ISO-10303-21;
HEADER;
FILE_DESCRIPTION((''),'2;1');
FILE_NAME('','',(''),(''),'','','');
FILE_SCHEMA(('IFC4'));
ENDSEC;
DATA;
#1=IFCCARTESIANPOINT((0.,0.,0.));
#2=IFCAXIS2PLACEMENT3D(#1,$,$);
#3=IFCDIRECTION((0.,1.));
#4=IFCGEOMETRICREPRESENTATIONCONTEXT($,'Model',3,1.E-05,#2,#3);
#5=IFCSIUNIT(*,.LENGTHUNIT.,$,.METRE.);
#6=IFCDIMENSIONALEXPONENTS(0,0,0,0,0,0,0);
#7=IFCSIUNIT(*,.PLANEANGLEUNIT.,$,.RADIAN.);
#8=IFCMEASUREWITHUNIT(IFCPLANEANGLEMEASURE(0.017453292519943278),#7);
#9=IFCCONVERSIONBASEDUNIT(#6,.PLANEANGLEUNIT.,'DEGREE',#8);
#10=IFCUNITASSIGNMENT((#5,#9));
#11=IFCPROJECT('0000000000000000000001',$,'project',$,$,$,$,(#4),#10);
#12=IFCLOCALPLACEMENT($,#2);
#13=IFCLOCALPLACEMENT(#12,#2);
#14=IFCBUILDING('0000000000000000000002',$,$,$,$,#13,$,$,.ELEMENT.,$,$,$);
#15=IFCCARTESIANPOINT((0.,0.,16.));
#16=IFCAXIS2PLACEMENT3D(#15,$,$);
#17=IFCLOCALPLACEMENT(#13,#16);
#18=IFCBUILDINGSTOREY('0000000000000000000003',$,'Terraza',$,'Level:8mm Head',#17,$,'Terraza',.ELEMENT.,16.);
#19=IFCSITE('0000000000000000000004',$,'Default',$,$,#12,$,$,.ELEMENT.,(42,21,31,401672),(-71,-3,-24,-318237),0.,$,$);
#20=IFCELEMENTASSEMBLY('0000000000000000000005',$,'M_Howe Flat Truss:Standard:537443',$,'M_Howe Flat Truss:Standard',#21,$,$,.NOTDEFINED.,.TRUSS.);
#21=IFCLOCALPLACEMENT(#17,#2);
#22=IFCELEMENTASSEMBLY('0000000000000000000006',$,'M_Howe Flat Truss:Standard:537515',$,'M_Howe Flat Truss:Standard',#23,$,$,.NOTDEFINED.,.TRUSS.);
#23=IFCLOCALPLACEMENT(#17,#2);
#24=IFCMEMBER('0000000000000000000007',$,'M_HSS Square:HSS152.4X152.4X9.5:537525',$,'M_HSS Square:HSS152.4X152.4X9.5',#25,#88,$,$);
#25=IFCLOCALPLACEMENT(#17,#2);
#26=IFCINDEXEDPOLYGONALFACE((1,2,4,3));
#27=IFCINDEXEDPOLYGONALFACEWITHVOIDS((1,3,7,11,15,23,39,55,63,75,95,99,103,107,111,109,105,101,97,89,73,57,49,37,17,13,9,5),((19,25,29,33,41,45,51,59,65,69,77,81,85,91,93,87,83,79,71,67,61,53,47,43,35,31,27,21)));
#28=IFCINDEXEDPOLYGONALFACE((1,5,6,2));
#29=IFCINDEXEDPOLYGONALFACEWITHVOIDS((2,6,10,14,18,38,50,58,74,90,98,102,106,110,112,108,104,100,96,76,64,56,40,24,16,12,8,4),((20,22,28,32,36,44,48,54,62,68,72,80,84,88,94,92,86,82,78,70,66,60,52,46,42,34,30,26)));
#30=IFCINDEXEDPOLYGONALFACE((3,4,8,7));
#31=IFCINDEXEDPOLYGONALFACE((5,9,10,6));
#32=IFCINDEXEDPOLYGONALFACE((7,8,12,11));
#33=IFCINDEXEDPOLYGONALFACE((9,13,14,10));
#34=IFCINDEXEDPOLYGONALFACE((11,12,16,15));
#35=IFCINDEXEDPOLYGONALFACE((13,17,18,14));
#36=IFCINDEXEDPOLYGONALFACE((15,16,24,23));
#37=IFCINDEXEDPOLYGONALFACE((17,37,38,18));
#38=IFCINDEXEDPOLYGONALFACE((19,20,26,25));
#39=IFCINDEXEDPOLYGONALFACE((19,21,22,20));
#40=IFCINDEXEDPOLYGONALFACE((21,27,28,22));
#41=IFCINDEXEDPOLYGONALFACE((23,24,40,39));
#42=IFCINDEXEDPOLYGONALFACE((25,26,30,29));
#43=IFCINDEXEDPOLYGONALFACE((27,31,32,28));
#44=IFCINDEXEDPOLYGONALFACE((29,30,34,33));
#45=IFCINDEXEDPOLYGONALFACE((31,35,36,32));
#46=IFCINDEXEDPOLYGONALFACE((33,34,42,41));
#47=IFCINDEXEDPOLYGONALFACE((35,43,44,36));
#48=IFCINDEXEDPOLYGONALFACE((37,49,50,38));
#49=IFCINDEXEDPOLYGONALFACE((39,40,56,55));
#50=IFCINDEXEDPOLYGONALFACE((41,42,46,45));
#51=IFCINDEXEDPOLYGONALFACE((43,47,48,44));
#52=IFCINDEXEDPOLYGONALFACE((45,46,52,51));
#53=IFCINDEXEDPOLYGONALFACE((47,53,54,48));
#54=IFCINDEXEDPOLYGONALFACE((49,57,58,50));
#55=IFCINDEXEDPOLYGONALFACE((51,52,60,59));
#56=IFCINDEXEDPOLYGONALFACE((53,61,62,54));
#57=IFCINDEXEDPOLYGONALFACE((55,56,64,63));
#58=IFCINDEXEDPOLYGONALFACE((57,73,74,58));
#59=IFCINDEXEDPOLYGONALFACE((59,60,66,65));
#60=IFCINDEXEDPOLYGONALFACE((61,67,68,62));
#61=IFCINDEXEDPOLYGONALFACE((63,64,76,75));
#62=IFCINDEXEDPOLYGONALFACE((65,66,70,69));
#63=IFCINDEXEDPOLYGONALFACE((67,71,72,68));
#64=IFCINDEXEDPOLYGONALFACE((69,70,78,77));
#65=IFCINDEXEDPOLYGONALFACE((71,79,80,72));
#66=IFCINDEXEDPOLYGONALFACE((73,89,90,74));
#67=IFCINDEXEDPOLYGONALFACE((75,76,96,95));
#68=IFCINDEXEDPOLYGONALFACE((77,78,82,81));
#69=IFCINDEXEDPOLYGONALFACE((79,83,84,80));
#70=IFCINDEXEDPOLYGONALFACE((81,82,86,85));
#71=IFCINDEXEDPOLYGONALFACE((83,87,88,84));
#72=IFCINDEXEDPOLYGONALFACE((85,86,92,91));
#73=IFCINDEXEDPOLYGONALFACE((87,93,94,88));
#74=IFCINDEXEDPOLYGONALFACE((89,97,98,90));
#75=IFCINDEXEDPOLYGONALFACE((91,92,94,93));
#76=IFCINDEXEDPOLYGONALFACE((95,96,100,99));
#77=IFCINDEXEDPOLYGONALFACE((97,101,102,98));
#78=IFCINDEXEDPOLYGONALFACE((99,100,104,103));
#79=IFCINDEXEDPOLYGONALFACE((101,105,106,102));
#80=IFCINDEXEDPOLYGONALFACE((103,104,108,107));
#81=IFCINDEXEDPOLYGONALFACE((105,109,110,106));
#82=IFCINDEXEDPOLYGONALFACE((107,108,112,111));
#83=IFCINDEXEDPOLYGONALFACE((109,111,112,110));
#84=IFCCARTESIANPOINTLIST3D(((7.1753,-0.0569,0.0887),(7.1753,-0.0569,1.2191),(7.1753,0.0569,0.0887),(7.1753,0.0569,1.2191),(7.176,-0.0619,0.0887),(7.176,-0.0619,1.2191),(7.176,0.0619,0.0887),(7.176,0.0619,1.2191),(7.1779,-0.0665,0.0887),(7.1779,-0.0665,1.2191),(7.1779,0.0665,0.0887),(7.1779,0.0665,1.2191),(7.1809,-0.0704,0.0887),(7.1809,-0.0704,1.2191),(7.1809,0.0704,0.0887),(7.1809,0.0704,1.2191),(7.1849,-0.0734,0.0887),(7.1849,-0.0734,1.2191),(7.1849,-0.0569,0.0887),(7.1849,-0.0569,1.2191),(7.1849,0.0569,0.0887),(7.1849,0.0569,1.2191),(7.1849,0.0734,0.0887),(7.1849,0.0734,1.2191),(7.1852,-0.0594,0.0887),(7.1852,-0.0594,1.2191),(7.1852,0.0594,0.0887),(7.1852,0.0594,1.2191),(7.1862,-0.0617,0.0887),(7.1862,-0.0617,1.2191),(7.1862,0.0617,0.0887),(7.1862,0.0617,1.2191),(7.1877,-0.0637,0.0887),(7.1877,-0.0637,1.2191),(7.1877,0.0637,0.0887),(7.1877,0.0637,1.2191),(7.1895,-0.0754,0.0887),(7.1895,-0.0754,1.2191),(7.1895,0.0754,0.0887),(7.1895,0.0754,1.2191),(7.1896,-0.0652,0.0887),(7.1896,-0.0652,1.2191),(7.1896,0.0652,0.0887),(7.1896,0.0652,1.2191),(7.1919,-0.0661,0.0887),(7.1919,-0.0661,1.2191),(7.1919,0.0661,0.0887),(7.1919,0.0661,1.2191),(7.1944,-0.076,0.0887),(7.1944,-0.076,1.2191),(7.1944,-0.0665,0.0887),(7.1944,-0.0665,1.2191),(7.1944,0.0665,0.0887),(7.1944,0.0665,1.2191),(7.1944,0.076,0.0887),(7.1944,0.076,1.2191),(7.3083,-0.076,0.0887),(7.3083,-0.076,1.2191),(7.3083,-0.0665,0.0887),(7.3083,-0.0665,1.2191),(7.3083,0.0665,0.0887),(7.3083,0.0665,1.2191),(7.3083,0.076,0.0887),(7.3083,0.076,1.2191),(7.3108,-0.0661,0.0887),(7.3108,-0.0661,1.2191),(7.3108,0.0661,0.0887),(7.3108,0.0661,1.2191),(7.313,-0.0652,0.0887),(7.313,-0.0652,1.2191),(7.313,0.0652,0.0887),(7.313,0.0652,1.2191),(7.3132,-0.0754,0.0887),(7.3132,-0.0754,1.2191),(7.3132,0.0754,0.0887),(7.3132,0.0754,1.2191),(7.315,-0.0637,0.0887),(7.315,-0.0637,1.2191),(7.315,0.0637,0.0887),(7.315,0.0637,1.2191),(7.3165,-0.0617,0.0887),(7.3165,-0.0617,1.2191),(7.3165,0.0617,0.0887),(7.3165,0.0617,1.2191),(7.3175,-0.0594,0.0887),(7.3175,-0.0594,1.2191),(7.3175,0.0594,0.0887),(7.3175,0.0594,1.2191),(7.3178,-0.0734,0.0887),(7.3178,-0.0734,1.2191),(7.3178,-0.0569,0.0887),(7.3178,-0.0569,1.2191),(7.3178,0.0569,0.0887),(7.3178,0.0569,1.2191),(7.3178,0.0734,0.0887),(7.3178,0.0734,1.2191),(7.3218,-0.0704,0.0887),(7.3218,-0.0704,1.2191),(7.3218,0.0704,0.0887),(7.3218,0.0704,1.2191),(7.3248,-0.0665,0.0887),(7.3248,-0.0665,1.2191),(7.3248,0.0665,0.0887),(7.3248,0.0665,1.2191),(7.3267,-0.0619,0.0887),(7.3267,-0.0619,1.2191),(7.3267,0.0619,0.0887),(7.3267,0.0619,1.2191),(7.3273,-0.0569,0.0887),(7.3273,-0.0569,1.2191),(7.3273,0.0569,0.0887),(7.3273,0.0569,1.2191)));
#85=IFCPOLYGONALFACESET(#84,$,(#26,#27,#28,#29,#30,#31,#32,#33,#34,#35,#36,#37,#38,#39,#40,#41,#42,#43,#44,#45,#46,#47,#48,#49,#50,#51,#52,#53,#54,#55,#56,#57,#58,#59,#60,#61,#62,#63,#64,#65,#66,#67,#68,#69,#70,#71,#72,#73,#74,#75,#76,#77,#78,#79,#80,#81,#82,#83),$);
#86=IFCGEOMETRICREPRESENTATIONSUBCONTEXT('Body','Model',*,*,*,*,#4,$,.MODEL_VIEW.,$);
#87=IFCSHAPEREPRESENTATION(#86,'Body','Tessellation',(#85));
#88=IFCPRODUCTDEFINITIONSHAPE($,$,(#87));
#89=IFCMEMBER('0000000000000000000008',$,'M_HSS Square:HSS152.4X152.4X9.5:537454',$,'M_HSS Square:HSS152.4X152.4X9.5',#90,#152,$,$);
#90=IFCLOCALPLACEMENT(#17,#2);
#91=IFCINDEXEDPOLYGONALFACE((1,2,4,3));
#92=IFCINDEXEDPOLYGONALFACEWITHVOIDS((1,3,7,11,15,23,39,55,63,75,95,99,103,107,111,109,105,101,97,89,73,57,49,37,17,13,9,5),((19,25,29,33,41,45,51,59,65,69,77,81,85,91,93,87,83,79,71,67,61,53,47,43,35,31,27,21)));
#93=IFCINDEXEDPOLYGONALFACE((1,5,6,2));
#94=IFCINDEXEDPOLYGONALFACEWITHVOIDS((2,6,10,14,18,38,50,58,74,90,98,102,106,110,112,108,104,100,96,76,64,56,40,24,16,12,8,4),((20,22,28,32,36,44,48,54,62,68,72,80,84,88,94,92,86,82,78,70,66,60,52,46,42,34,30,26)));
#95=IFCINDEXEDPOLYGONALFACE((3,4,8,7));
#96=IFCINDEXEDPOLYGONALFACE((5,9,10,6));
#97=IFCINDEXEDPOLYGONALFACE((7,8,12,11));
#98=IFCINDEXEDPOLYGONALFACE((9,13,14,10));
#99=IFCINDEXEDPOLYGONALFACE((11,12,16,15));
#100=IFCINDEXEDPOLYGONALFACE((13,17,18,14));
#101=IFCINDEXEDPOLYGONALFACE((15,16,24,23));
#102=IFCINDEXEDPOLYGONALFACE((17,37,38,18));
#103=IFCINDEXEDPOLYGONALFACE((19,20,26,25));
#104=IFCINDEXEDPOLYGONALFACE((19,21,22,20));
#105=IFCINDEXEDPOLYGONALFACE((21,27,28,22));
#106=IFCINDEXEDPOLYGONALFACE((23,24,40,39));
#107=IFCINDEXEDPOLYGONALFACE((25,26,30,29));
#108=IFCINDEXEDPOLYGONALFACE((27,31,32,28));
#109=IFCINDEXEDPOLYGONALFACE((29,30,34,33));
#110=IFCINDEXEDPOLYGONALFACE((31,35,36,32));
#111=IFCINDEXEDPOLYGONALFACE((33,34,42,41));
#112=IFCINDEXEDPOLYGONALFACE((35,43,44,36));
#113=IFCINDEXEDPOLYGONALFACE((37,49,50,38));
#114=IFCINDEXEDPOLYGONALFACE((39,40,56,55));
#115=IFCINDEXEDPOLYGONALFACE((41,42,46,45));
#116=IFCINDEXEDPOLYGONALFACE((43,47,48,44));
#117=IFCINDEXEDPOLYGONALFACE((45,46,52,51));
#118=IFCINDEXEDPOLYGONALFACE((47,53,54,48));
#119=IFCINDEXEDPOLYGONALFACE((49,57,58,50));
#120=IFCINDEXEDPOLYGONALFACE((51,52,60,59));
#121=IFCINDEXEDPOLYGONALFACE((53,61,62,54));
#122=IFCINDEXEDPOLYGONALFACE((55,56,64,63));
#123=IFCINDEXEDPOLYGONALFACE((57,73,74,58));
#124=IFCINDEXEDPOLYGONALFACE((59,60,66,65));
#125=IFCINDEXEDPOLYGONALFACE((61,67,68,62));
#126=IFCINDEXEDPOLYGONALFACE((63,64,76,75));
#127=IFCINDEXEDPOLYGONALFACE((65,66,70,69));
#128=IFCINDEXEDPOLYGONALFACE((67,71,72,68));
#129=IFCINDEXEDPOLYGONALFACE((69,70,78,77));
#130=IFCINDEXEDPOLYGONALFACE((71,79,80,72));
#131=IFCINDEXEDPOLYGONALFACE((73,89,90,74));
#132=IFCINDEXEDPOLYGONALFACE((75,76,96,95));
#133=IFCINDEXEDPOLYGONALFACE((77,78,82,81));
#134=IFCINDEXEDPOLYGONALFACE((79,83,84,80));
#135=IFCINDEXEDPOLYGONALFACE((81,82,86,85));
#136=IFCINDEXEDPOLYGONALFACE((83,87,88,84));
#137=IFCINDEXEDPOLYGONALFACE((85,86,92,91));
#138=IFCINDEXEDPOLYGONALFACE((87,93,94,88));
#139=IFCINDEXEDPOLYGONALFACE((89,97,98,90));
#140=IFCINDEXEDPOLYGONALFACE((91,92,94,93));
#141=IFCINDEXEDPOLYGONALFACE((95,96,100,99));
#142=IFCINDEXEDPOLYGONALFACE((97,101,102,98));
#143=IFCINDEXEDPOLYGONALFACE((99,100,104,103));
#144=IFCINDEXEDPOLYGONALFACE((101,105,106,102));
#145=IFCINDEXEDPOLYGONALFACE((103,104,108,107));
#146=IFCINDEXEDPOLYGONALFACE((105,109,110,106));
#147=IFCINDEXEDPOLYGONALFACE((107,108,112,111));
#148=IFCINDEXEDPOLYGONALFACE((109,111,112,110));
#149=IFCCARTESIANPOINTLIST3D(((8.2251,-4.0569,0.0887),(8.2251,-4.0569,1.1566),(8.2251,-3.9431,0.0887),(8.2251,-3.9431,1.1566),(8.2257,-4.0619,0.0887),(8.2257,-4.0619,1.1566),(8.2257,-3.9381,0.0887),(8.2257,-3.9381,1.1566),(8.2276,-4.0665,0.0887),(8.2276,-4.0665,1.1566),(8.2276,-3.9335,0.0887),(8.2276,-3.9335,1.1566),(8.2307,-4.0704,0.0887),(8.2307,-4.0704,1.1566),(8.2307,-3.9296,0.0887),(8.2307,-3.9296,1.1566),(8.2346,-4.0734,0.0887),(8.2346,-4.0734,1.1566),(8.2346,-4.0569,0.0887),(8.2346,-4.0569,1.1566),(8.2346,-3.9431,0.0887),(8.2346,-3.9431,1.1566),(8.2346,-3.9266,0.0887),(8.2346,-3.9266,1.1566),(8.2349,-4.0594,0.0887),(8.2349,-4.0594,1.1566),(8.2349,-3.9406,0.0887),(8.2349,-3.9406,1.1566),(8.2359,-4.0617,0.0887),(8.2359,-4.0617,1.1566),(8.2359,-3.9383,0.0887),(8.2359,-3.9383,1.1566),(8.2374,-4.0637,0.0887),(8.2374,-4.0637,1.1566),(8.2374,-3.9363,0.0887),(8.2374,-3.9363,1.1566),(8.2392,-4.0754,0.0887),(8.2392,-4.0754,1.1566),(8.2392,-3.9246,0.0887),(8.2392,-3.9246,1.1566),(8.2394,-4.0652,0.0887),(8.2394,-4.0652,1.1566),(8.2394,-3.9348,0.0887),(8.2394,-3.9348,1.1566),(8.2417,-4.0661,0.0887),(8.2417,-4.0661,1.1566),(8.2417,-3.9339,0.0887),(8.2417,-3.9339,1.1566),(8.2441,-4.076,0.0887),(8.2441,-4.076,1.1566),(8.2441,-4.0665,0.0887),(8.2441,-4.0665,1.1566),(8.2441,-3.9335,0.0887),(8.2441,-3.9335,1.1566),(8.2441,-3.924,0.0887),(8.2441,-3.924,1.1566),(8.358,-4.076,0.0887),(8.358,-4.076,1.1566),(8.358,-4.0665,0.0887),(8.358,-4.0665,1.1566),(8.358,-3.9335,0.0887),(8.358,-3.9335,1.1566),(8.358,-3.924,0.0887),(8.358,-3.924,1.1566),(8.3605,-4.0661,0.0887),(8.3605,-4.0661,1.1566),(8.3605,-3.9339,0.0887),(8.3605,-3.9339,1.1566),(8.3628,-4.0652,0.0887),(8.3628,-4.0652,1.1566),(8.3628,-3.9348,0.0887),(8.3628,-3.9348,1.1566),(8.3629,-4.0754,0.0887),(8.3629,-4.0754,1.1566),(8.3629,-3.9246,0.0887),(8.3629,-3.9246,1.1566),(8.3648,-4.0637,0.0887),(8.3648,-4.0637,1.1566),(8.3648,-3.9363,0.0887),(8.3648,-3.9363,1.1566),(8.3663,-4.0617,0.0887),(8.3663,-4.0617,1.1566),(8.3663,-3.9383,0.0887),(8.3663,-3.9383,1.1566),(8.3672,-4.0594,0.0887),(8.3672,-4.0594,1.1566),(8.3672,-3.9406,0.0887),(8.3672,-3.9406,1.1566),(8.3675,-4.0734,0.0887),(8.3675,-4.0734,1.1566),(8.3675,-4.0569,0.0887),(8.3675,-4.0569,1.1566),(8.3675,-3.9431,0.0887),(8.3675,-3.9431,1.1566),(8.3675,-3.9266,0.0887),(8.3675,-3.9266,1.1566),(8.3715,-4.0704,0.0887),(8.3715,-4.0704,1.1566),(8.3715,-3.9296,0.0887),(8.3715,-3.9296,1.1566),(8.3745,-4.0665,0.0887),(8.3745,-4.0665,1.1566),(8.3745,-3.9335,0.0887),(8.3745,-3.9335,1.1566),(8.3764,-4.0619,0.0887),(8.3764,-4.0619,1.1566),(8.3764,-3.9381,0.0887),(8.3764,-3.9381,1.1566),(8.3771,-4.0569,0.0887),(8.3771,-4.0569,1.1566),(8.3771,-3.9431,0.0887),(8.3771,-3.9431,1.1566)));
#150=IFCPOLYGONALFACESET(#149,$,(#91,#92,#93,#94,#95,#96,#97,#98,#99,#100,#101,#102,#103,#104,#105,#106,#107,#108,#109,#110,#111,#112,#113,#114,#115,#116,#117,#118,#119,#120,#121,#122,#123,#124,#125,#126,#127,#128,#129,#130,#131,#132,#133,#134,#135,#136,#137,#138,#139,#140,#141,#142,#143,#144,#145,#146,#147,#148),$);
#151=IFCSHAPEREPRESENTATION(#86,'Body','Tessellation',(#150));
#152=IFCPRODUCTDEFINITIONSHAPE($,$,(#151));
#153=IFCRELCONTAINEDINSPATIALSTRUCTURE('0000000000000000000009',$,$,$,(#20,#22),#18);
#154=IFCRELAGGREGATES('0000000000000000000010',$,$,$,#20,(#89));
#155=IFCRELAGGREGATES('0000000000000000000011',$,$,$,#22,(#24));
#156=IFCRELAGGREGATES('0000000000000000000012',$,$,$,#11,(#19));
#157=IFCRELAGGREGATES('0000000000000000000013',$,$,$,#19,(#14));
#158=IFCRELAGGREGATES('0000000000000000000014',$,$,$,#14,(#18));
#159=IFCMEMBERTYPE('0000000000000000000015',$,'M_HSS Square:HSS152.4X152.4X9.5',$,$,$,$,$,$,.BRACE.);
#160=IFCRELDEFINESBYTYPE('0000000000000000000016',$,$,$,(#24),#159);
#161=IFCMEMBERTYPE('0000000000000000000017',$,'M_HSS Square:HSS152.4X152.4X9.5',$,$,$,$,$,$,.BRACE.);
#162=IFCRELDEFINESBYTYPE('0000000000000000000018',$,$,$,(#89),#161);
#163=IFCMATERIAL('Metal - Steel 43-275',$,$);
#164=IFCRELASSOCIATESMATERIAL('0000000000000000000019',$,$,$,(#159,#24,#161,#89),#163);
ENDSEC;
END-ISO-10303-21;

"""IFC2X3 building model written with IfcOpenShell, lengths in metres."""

from ifc_helpers import new_model, entity, si_unit, converted_unit, direction, frame, frame_2d, origin, place, context, subcontext, project, spatial, polyline, circle_curve, parameter, trimmed, segment, composite_curve, outline, extrude, source, transform, mapped, material, type_object, type_shapes, element, aggregate, save


model = new_model("IFC2X3")

# Units and contexts
model_context = context("Model", 3, precision=1e-05, world=origin(), true_north=direction((0.0, 1.0)))
body_context = subcontext(model_context, "Body", "Model", "MODEL_VIEW")
ifc_project = project(units=[si_unit("LENGTHUNIT", "METRE"), converted_unit("PLANEANGLEUNIT", "DEGREE", entity("IfcPlaneAngleMeasure", 0.017453292519943278), si_unit("PLANEANGLEUNIT", "RADIAN"), dimensions=[0, 0, 0, 0, 0, 0, 0])], contexts=[model_context])

# Site, building, storey
site_placement = place(None, origin())
site = spatial("IfcSite", under=ifc_project, at=site_placement, Name="Default", CompositionType="ELEMENT", RefLatitude=(42, 21, 31, 401672), RefLongitude=(-71, -3, -24, -318237), RefElevation=0.0)
building_placement = place(site_placement, origin())
building = spatial("IfcBuilding", under=site, at=building_placement, CompositionType="ELEMENT")
storey_placement = place(building_placement, frame((0.0, 0.0, 16.0)))
storey = spatial("IfcBuildingStorey", under=building, at=storey_placement, Name="Terraza", ObjectType="Level:8mm Head", LongName="Terraza", CompositionType="ELEMENT", Elevation=16.0)

# Element assemblies
ifc_material_1 = material(Name="Metal - Steel 43-275")
assembly_1_placement = place(storey_placement, origin())
assembly_1 = element("IfcElementAssembly", 1, at=assembly_1_placement, inside=storey, Name="M_Howe Flat Truss:Standard:537443", ObjectType="M_Howe Flat Truss:Standard", AssemblyPlace="NOTDEFINED", PredefinedType="TRUSS")
assembly_2_placement = place(storey_placement, origin())
assembly_2 = element("IfcElementAssembly", 2, at=assembly_2_placement, inside=storey, Name="M_Howe Flat Truss:Standard:537515", ObjectType="M_Howe Flat Truss:Standard", AssemblyPlace="NOTDEFINED", PredefinedType="TRUSS")

# Members
member_type_1 = type_object("IfcMemberType", Name="M_HSS Square:HSS152.4X152.4X9.5", PredefinedType="BRACE", material=ifc_material_1)
shared_shape_1 = source(origin(), body_context, "Body", "SweptSolid", [
    extrude(outline(composite_curve([segment(polyline([(-0.0569, -0.076), (0.0569, -0.076)]), True, "CONTINUOUS"), segment(trimmed(circle_curve(frame_2d((0.0569, -0.0569), x_axis=(0.0, 1.0)), 0.0191), [parameter(180.0)], [parameter(270.0)], True, "PARAMETER"), True, "CONTINUOUS"), segment(polyline([(0.076, -0.0569), (0.076, 0.0569)]), True, "CONTINUOUS"), segment(trimmed(circle_curve(frame_2d((0.0569, 0.0569), x_axis=(0.0, 1.0)), 0.0191), [parameter(270.0)], [parameter(0.0)], True, "PARAMETER"), True, "CONTINUOUS"), segment(polyline([(0.0569, 0.076), (-0.0569, 0.076)]), True, "CONTINUOUS"), segment(trimmed(circle_curve(frame_2d((-0.0569, 0.0569), x_axis=(0.0, 1.0)), 0.0191), [parameter(0.0)], [parameter(90.0)], True, "PARAMETER"), True, "CONTINUOUS"), segment(polyline([(-0.076, 0.0569), (-0.076, -0.0569)]), True, "CONTINUOUS"), segment(trimmed(circle_curve(frame_2d((-0.0569, -0.0569), x_axis=(0.0, 1.0)), 0.0191), [parameter(90.0)], [parameter(180.0)], True, "PARAMETER"), True, "CONTINUOUS")], self_intersect=False), holes=[composite_curve([segment(trimmed(circle_curve(frame_2d((-0.0569, 0.0569), x_axis=(0.0, 1.0)), 0.0095), [parameter(360.0)], [parameter(90.0)], True, "PARAMETER"), False, "CONTINUOUS"), segment(polyline([(-0.0569, 0.0665), (0.0569, 0.0665)]), True, "CONTINUOUS"), segment(trimmed(circle_curve(frame_2d((0.0569, 0.0569), x_axis=(0.0, 1.0)), 0.0095), [parameter(270.0)], [parameter(360.0)], True, "PARAMETER"), False, "CONTINUOUS"), segment(polyline([(0.0665, 0.0569), (0.0665, -0.0569)]), True, "CONTINUOUS"), segment(trimmed(circle_curve(frame_2d((0.0569, -0.0569), x_axis=(0.0, 1.0)), 0.0095), [parameter(180.0)], [parameter(270.0)], True, "PARAMETER"), False, "CONTINUOUS"), segment(polyline([(0.0569, -0.0665), (-0.0569, -0.0665)]), True, "CONTINUOUS"), segment(trimmed(circle_curve(frame_2d((-0.0569, -0.0569), x_axis=(0.0, 1.0)), 0.0095), [parameter(90.0)], [parameter(180.0)], True, "PARAMETER"), False, "CONTINUOUS"), segment(polyline([(-0.0665, -0.0569), (-0.0665, 0.0569)]), True, "CONTINUOUS")], self_intersect=False)]), frame((-0.5675, 0.0, 0.0), z_axis=(1.0, 0.0, 0.0), x_axis=(0.0, 0.0, -1.0)), (0.0, 0.0, 1.0), 1.1304),
])
type_shapes(member_type_1, [shared_shape_1])
member_1_placement = place(assembly_2_placement, frame((7.2513, 0.0, 0.6562), z_axis=(1.0, 0.0, 0.0), x_axis=(0.0, 0.0, 1.0)))
member_1 = element("IfcMember", 3, at=member_1_placement, type_object=member_type_1, material=ifc_material_1, Name="M_HSS Square:HSS152.4X152.4X9.5:537525", ObjectType="M_HSS Square:HSS152.4X152.4X9.5", context=body_context, shape_type="MappedRepresentation", body=[
    mapped(shared_shape_1, transform((0.0, 0.0, 0.0), scale=1.0)),
])
member_type_2 = type_object("IfcMemberType", Name="M_HSS Square:HSS152.4X152.4X9.5", PredefinedType="BRACE", material=ifc_material_1)
shared_shape_2 = source(origin(), body_context, "Body", "SweptSolid", [
    extrude(outline(composite_curve([segment(polyline([(-0.0569, -0.076), (0.0569, -0.076)]), True, "CONTINUOUS"), segment(trimmed(circle_curve(frame_2d((0.0569, -0.0569), x_axis=(0.0, 1.0)), 0.0191), [parameter(180.0)], [parameter(270.0)], True, "PARAMETER"), True, "CONTINUOUS"), segment(polyline([(0.076, -0.0569), (0.076, 0.0569)]), True, "CONTINUOUS"), segment(trimmed(circle_curve(frame_2d((0.0569, 0.0569), x_axis=(0.0, 1.0)), 0.0191), [parameter(270.0)], [parameter(0.0)], True, "PARAMETER"), True, "CONTINUOUS"), segment(polyline([(0.0569, 0.076), (-0.0569, 0.076)]), True, "CONTINUOUS"), segment(trimmed(circle_curve(frame_2d((-0.0569, 0.0569), x_axis=(0.0, 1.0)), 0.0191), [parameter(0.0)], [parameter(90.0)], True, "PARAMETER"), True, "CONTINUOUS"), segment(polyline([(-0.076, 0.0569), (-0.076, -0.0569)]), True, "CONTINUOUS"), segment(trimmed(circle_curve(frame_2d((-0.0569, -0.0569), x_axis=(0.0, 1.0)), 0.0191), [parameter(90.0)], [parameter(180.0)], True, "PARAMETER"), True, "CONTINUOUS")], self_intersect=False), holes=[composite_curve([segment(trimmed(circle_curve(frame_2d((-0.0569, 0.0569), x_axis=(0.0, 1.0)), 0.0095), [parameter(360.0)], [parameter(90.0)], True, "PARAMETER"), False, "CONTINUOUS"), segment(polyline([(-0.0569, 0.0665), (0.0569, 0.0665)]), True, "CONTINUOUS"), segment(trimmed(circle_curve(frame_2d((0.0569, 0.0569), x_axis=(0.0, 1.0)), 0.0095), [parameter(270.0)], [parameter(360.0)], True, "PARAMETER"), False, "CONTINUOUS"), segment(polyline([(0.0665, 0.0569), (0.0665, -0.0569)]), True, "CONTINUOUS"), segment(trimmed(circle_curve(frame_2d((0.0569, -0.0569), x_axis=(0.0, 1.0)), 0.0095), [parameter(180.0)], [parameter(270.0)], True, "PARAMETER"), False, "CONTINUOUS"), segment(polyline([(0.0569, -0.0665), (-0.0569, -0.0665)]), True, "CONTINUOUS"), segment(trimmed(circle_curve(frame_2d((-0.0569, -0.0569), x_axis=(0.0, 1.0)), 0.0095), [parameter(90.0)], [parameter(180.0)], True, "PARAMETER"), False, "CONTINUOUS"), segment(polyline([(-0.0665, -0.0569), (-0.0665, 0.0569)]), True, "CONTINUOUS")], self_intersect=False)]), frame((-0.5363, 0.0, 0.0), z_axis=(1.0, 0.0, 0.0), x_axis=(0.0, 0.0, -1.0)), (0.0, 0.0, 1.0), 1.0679),
])
type_shapes(member_type_2, [shared_shape_2])
member_2_placement = place(assembly_1_placement, frame((8.3011, -4.0, 0.625), z_axis=(1.0, 0.0, 0.0), x_axis=(0.0, 0.0, 1.0)))
member_2 = element("IfcMember", 4, at=member_2_placement, type_object=member_type_2, material=ifc_material_1, Name="M_HSS Square:HSS152.4X152.4X9.5:537454", ObjectType="M_HSS Square:HSS152.4X152.4X9.5", context=body_context, shape_type="MappedRepresentation", body=[
    mapped(shared_shape_2, transform((0.0, 0.0, 0.0), scale=1.0)),
])
aggregate(assembly_1, [member_2])
aggregate(assembly_2, [member_1])

save(model, "model.ifc")
